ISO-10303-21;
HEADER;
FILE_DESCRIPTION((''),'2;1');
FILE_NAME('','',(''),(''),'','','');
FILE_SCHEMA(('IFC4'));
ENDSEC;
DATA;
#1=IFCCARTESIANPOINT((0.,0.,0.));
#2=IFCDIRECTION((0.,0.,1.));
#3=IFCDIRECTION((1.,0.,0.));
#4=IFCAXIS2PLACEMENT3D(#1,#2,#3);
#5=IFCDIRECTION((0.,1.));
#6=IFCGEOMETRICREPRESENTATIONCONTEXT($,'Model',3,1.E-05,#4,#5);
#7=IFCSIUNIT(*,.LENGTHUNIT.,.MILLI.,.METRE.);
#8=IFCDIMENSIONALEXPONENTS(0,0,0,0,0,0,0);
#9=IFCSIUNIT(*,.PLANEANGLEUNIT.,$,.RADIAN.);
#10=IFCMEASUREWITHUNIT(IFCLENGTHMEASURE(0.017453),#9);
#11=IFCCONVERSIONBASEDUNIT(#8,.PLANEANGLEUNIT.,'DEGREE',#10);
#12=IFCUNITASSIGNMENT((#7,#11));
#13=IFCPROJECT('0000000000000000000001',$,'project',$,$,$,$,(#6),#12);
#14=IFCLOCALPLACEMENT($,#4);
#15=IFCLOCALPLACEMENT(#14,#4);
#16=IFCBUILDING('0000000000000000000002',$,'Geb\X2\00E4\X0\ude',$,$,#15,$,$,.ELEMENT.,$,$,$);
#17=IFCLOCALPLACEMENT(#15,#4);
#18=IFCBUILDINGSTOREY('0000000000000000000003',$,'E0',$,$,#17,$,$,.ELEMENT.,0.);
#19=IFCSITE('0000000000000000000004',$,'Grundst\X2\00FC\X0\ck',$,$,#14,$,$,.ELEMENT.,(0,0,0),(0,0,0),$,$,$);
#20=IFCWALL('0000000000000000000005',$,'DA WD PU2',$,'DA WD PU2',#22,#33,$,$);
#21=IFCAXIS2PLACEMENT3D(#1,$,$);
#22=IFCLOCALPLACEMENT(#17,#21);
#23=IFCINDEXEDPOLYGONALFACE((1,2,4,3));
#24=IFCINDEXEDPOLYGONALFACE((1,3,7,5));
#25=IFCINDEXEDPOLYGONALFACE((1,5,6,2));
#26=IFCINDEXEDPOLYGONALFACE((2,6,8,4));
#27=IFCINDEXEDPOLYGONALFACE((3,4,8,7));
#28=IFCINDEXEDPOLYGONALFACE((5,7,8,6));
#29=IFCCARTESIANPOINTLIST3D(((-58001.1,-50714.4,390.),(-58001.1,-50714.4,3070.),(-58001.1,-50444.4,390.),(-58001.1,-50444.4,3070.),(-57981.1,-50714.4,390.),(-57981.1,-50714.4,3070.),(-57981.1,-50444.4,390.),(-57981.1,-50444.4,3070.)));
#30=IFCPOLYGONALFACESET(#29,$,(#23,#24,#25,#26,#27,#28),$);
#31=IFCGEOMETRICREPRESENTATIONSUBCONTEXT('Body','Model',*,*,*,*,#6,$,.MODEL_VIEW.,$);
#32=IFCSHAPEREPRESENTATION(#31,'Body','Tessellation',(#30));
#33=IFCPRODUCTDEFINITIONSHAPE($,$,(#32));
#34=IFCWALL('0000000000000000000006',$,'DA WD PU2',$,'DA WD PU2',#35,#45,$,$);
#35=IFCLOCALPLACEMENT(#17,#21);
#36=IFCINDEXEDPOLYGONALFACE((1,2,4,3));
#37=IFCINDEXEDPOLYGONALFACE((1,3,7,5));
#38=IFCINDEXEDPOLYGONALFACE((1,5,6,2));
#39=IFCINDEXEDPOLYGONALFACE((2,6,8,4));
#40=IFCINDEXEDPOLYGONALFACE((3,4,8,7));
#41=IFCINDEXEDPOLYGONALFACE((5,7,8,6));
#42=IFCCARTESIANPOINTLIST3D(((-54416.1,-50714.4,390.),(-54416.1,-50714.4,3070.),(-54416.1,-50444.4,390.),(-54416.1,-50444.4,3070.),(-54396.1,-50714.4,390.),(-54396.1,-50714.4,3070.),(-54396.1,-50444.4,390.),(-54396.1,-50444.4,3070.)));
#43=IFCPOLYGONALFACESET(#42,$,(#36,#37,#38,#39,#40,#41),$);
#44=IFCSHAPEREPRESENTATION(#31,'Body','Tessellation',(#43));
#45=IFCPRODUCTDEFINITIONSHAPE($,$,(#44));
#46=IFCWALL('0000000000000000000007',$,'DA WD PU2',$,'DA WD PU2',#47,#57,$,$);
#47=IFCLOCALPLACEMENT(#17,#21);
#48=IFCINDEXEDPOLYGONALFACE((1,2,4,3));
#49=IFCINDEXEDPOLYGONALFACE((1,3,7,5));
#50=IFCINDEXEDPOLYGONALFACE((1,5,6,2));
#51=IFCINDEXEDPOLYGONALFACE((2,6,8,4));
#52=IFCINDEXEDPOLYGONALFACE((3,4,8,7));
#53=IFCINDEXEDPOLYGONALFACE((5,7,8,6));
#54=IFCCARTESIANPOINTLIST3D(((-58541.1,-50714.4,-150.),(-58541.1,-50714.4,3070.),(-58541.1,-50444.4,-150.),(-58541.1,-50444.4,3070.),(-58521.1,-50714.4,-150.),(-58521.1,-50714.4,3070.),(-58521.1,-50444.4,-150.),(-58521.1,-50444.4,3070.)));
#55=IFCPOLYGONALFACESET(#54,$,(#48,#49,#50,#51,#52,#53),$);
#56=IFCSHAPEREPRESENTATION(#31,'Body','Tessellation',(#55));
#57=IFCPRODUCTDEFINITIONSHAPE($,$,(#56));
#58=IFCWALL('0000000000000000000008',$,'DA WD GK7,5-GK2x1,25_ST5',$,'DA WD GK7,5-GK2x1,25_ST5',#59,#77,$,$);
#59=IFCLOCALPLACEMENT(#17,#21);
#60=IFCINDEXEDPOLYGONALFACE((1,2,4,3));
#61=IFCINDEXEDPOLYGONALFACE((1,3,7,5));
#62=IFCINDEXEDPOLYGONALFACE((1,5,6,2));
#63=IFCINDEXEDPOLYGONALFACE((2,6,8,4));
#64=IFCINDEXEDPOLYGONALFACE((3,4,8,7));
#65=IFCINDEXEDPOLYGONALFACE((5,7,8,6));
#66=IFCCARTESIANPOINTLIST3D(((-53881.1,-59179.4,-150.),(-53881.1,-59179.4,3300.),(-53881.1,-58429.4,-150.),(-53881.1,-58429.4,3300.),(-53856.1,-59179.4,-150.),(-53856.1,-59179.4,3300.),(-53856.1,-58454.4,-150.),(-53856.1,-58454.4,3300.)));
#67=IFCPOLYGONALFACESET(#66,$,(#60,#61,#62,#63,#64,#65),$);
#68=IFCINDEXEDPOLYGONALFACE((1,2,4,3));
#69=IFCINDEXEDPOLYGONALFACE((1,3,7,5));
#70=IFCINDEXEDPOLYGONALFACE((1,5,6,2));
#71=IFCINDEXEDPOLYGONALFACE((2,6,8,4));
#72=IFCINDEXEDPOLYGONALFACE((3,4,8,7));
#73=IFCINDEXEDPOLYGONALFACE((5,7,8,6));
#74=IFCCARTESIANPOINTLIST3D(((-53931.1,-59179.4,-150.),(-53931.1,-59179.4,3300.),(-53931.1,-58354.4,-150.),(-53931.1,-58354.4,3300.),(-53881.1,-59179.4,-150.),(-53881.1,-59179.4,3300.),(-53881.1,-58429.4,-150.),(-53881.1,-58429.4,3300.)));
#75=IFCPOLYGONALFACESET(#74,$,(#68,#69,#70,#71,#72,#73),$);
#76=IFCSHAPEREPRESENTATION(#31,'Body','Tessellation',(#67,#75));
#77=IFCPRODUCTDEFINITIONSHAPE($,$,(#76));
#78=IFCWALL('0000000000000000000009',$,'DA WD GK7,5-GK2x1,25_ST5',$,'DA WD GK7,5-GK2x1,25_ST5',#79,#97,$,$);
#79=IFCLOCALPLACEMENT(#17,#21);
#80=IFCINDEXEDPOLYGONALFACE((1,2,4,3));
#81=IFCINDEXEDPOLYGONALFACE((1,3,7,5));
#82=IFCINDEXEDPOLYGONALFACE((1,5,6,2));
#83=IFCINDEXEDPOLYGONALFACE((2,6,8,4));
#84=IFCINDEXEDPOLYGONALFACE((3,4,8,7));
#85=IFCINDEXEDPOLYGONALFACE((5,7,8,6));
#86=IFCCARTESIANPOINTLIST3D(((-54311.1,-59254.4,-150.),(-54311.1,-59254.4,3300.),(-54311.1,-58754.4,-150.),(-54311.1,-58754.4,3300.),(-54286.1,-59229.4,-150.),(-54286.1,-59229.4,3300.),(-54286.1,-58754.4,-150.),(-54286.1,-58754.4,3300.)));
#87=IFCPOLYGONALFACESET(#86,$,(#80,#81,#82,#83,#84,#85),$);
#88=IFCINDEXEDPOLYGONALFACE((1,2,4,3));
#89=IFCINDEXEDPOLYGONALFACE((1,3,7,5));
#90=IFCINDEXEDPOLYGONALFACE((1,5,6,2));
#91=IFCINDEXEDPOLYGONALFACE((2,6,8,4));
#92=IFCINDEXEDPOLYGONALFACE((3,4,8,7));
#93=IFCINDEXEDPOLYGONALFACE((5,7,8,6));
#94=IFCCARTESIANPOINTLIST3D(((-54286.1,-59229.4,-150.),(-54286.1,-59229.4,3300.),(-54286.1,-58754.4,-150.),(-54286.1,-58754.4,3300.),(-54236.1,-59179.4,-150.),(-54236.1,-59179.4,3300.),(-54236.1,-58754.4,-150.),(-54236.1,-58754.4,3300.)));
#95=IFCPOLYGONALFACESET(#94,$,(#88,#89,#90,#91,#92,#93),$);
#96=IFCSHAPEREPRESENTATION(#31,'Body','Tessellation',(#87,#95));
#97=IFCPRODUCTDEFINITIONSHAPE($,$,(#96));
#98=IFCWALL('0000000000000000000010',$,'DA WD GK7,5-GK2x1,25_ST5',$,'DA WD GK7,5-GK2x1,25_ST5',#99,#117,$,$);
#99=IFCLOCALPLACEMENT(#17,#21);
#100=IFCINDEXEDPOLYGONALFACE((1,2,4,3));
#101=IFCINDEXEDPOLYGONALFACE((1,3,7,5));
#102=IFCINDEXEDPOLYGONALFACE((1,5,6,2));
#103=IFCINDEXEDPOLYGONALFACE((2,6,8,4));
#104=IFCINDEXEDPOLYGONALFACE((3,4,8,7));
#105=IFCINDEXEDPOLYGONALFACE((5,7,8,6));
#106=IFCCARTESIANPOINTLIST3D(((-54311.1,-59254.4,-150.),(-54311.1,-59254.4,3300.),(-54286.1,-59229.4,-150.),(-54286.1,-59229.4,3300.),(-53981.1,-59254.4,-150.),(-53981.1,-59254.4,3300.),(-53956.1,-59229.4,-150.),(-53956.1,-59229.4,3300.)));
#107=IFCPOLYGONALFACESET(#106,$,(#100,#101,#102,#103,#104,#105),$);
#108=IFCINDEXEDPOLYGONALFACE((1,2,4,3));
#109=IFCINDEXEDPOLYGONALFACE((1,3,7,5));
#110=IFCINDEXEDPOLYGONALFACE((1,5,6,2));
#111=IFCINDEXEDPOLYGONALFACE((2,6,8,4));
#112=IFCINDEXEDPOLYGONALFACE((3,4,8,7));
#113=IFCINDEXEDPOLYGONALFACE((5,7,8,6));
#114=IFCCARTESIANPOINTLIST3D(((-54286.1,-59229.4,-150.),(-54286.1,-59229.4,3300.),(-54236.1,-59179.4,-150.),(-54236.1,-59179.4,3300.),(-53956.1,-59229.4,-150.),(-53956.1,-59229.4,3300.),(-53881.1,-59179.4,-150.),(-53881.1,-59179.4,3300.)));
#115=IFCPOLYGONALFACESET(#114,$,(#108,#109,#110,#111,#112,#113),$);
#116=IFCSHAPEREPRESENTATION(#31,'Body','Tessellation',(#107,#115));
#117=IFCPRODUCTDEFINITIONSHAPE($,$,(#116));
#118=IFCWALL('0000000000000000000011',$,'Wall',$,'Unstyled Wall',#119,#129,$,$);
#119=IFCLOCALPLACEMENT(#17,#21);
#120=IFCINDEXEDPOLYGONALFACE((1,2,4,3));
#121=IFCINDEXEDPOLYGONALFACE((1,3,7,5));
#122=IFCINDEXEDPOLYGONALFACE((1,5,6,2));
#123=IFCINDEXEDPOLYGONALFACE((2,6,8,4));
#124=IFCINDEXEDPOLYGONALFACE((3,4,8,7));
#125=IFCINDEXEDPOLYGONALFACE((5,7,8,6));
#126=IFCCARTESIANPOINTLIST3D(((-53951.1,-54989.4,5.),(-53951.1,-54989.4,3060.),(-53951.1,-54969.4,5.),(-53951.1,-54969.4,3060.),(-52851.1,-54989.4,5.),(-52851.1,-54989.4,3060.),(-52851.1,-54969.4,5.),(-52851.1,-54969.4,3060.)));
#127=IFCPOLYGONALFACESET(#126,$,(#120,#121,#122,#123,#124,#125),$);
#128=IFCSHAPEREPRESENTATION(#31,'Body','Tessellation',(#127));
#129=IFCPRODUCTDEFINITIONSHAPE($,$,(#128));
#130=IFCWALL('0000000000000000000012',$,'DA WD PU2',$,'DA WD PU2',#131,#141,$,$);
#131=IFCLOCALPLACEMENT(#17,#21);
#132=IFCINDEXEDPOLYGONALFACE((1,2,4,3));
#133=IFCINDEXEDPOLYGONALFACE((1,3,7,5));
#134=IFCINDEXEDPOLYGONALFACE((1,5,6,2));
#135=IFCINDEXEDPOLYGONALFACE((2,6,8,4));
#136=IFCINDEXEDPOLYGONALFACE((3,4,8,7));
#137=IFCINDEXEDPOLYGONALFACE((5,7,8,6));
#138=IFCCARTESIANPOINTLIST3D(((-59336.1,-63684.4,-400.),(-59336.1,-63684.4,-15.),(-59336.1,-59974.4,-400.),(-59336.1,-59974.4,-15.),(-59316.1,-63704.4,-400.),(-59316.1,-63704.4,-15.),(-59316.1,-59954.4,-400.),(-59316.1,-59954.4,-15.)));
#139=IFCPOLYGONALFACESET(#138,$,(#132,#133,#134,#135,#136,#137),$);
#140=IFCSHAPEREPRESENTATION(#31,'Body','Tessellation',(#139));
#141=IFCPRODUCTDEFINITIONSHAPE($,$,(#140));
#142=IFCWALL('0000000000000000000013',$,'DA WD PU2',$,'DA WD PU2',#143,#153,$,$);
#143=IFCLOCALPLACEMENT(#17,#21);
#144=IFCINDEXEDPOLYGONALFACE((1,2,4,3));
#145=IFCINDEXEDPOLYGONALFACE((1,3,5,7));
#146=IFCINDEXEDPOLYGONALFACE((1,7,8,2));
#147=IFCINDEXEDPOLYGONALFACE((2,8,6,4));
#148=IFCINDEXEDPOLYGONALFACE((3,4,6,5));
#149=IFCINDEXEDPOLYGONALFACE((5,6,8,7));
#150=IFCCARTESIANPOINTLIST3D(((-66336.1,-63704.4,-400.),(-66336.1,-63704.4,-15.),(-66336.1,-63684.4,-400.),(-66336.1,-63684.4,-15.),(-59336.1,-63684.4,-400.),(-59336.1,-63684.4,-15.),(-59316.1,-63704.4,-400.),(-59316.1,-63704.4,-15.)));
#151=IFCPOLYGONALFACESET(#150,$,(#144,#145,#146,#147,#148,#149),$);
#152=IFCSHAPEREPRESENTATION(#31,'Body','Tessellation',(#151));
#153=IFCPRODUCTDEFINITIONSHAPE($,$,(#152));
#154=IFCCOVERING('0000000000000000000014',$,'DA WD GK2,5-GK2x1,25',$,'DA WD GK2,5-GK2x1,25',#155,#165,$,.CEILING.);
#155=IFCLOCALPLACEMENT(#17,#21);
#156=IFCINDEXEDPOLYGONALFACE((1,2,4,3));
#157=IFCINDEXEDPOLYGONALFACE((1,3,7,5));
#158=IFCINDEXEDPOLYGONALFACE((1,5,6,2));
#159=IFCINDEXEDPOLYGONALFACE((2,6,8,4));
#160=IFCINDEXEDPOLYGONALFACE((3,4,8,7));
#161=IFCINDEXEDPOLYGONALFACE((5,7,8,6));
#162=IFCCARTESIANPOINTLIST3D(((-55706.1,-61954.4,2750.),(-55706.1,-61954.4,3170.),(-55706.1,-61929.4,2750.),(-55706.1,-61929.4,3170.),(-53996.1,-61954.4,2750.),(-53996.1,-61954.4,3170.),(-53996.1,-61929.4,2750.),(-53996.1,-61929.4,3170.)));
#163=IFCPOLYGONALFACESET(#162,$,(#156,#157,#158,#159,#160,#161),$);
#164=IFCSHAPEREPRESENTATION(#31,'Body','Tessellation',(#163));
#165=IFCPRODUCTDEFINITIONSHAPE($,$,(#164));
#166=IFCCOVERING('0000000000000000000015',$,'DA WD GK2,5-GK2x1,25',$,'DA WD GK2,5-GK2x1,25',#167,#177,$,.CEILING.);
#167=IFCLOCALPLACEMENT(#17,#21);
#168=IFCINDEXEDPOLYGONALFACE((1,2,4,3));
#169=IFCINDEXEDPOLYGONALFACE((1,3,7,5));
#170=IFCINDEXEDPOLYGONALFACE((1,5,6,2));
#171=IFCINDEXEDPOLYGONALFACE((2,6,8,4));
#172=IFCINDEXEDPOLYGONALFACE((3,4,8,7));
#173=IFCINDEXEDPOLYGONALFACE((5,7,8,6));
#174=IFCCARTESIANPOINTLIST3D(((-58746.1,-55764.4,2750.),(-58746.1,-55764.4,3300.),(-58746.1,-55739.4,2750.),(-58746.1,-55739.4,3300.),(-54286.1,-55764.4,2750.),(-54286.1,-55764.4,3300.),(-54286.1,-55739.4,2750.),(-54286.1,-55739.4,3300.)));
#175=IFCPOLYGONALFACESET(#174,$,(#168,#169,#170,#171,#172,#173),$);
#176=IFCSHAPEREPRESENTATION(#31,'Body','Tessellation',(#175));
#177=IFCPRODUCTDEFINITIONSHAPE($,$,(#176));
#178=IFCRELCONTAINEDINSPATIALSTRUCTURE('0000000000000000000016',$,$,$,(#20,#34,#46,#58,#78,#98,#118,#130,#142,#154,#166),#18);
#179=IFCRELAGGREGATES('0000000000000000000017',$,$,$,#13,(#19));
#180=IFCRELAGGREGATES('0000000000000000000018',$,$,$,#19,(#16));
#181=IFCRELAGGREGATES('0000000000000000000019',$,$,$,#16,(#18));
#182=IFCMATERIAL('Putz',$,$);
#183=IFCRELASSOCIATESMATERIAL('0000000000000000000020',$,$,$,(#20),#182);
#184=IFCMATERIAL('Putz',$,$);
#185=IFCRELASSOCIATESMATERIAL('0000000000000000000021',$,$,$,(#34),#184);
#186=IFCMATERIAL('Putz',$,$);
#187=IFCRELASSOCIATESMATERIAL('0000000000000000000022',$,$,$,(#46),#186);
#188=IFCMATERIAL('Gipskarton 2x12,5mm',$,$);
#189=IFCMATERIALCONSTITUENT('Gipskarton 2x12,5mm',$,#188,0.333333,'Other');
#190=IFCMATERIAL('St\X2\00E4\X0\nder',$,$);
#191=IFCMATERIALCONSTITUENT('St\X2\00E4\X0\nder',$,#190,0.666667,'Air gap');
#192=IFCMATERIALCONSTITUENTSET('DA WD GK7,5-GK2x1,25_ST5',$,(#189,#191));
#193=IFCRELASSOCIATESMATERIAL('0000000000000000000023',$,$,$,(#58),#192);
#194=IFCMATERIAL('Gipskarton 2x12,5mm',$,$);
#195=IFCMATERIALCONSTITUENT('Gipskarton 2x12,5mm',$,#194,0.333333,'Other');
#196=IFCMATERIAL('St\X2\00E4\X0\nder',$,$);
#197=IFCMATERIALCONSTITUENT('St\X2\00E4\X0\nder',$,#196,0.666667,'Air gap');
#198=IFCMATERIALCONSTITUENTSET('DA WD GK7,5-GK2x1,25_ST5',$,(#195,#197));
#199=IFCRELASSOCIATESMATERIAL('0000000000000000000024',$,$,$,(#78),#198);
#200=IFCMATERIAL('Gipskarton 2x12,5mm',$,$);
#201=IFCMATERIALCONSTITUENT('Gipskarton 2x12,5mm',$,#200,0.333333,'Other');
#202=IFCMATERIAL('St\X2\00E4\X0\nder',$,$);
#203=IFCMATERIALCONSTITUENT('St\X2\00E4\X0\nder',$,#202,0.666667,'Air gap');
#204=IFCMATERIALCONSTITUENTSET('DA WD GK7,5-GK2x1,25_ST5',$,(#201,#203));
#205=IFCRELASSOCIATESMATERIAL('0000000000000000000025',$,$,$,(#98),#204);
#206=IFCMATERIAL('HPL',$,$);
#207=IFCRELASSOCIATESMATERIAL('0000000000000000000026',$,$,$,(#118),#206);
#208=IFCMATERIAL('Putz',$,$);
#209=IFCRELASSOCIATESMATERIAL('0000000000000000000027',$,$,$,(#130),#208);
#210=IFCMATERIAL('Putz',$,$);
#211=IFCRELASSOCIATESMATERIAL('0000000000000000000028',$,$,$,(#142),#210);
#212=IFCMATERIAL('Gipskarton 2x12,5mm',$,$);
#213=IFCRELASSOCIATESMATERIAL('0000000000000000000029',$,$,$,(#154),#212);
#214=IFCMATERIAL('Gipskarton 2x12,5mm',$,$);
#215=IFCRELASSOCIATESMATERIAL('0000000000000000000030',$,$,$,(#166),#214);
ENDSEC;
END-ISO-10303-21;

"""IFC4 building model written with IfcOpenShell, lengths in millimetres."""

from ifc_helpers import new_model, entity, si_unit, converted_unit, direction, frame, origin_with_axes, place, context, subcontext, project, spatial, line, indexed_curve, outline, extrude, material, constituent, constituent_set, element, save


model = new_model("IFC4")

# Units and contexts
model_context = context("Model", 3, precision=1e-05, world=origin_with_axes(), true_north=direction((0.0, 1.0)))
body_context = subcontext(model_context, "Body", "Model", "MODEL_VIEW")
ifc_project = project(units=[si_unit("LENGTHUNIT", "METRE", prefix="MILLI"), converted_unit("PLANEANGLEUNIT", "DEGREE", entity("IfcLengthMeasure", 0.017453), si_unit("PLANEANGLEUNIT", "RADIAN"), dimensions=[0, 0, 0, 0, 0, 0, 0])], contexts=[model_context])

# Site, building, storey
site_placement = place(None, origin_with_axes())
site = spatial("IfcSite", under=ifc_project, at=site_placement, Name="Grundstück", CompositionType="ELEMENT", RefLatitude=(0, 0, 0), RefLongitude=(0, 0, 0))
building_placement = place(site_placement, origin_with_axes())
building = spatial("IfcBuilding", under=site, at=building_placement, Name="Gebäude", CompositionType="ELEMENT")
storey_placement = place(building_placement, origin_with_axes())
storey = spatial("IfcBuildingStorey", under=building, at=storey_placement, Name="E0", CompositionType="ELEMENT", Elevation=0.0)

# Walls
ifc_material_1 = material(Name="Putz")
wall_1_placement = place(storey_placement, frame((-57991.1, -50714.4, 390.0), z_axis=(0.0, 0.0, 1.0), x_axis=(0.0, 1.0, 0.0)))
element("IfcWall", 1, at=wall_1_placement, inside=storey, material=ifc_material_1, Name="DA WD PU2", ObjectType="DA WD PU2", context=body_context, shape_type="SweptSolid", body=[
    extrude(outline(indexed_curve([(0.0, -10.0), (0.0, 10.0), (270.0, 10.0), (270.0, -10.0)], segments=[line(1, 2), line(2, 3), line(3, 4), line(4, 1)])), origin_with_axes(), (0.0, 0.0, 1.0), 2680.0),
])
ifc_material_2 = material(Name="Putz")
wall_2_placement = place(storey_placement, frame((-54406.1, -50714.4, 390.0), z_axis=(0.0, 0.0, 1.0), x_axis=(0.0, 1.0, 0.0)))
element("IfcWall", 2, at=wall_2_placement, inside=storey, material=ifc_material_2, Name="DA WD PU2", ObjectType="DA WD PU2", context=body_context, shape_type="SweptSolid", body=[
    extrude(outline(indexed_curve([(0.0, -10.0), (0.0, 10.0), (270.0, 10.0), (270.0, -10.0)], segments=[line(1, 2), line(2, 3), line(3, 4), line(4, 1)])), origin_with_axes(), (0.0, 0.0, 1.0), 2680.0),
])
ifc_material_3 = material(Name="Putz")
wall_3_placement = place(storey_placement, frame((-58531.1, -50714.4, -150.0), z_axis=(0.0, 0.0, 1.0), x_axis=(0.0, 1.0, 0.0)))
element("IfcWall", 3, at=wall_3_placement, inside=storey, material=ifc_material_3, Name="DA WD PU2", ObjectType="DA WD PU2", context=body_context, shape_type="SweptSolid", body=[
    extrude(outline(indexed_curve([(0.0, -10.0), (0.0, 10.0), (270.0, 10.0), (270.0, -10.0)], segments=[line(1, 2), line(2, 3), line(3, 4), line(4, 1)])), origin_with_axes(), (0.0, 0.0, 1.0), 3220.0),
])
ifc_material_4 = material(Name="Gipskarton 2x12,5mm")
ifc_constituent_1 = constituent(ifc_material_4, Name="Gipskarton 2x12,5mm", Category="Other", fraction=0.333333)
ifc_material_5 = material(Name="Ständer")
ifc_constituent_2 = constituent(ifc_material_5, Name="Ständer", Category="Air gap", fraction=0.666667)
ifc_constituent_set_1 = constituent_set(constituents=[ifc_constituent_1, ifc_constituent_2], Name="DA WD GK7,5-GK2x1,25_ST5")
wall_4_placement = place(storey_placement, frame((-53893.6, -58391.9, -150.0), z_axis=(0.0, 0.0, 1.0), x_axis=(0.0, -1.0, 0.0)))
element("IfcWall", 4, at=wall_4_placement, inside=storey, material=ifc_constituent_set_1, Name="DA WD GK7,5-GK2x1,25_ST5", ObjectType="DA WD GK7,5-GK2x1,25_ST5", context=body_context, shape_type="SweptSolid", body=[
    extrude(outline(indexed_curve([(787.5, 37.5), (787.5, 12.5), (37.5, 12.5), (62.5, 37.5)], segments=[line(1, 2), line(2, 3), line(3, 4), line(4, 1)])), origin_with_axes(), (0.0, 0.0, 1.0), 3450.0),
    extrude(outline(indexed_curve([(787.5, 12.5), (787.5, -37.5), (-37.5, -37.5), (37.5, 12.5)], segments=[line(1, 2), line(2, 3), line(3, 4), line(4, 1)])), origin_with_axes(), (0.0, 0.0, 1.0), 3450.0),
])
ifc_material_6 = material(Name="Gipskarton 2x12,5mm")
ifc_constituent_3 = constituent(ifc_material_6, Name="Gipskarton 2x12,5mm", Category="Other", fraction=0.333333)
ifc_material_7 = material(Name="Ständer")
ifc_constituent_4 = constituent(ifc_material_7, Name="Ständer", Category="Air gap", fraction=0.666667)
ifc_constituent_set_2 = constituent_set(constituents=[ifc_constituent_3, ifc_constituent_4], Name="DA WD GK7,5-GK2x1,25_ST5")
wall_5_placement = place(storey_placement, frame((-54273.6, -59216.9, -150.0), z_axis=(0.0, 0.0, 1.0), x_axis=(0.0, 1.0, 0.0)))
element("IfcWall", 5, at=wall_5_placement, inside=storey, material=ifc_constituent_set_2, Name="DA WD GK7,5-GK2x1,25_ST5", ObjectType="DA WD GK7,5-GK2x1,25_ST5", context=body_context, shape_type="SweptSolid", body=[
    extrude(outline(indexed_curve([(462.5, 37.5), (462.5, 12.5), (-12.5, 12.5), (-37.5, 37.5)], segments=[line(1, 2), line(2, 3), line(3, 4), line(4, 1)])), origin_with_axes(), (0.0, 0.0, 1.0), 3450.0),
    extrude(outline(indexed_curve([(462.5, 12.5), (462.5, -37.5), (37.5, -37.5), (-12.5, 12.5)], segments=[line(1, 2), line(2, 3), line(3, 4), line(4, 1)])), origin_with_axes(), (0.0, 0.0, 1.0), 3450.0),
])
ifc_material_8 = material(Name="Gipskarton 2x12,5mm")
ifc_constituent_5 = constituent(ifc_material_8, Name="Gipskarton 2x12,5mm", Category="Other", fraction=0.333333)
ifc_material_9 = material(Name="Ständer")
ifc_constituent_6 = constituent(ifc_material_9, Name="Ständer", Category="Air gap", fraction=0.666667)
ifc_constituent_set_3 = constituent_set(constituents=[ifc_constituent_5, ifc_constituent_6], Name="DA WD GK7,5-GK2x1,25_ST5")
wall_6_placement = place(storey_placement, frame((-53918.6, -59216.9, -150.0), z_axis=(0.0, 0.0, 1.0), x_axis=(-1.0, 0.0, 0.0)))
element("IfcWall", 6, at=wall_6_placement, inside=storey, material=ifc_constituent_set_3, Name="DA WD GK7,5-GK2x1,25_ST5", ObjectType="DA WD GK7,5-GK2x1,25_ST5", context=body_context, shape_type="SweptSolid", body=[
    extrude(outline(indexed_curve([(392.5, 37.5), (367.5, 12.5), (37.5, 12.5), (62.5, 37.5)], segments=[line(1, 2), line(2, 3), line(3, 4), line(4, 1)])), origin_with_axes(), (0.0, 0.0, 1.0), 3450.0),
    extrude(outline(indexed_curve([(367.5, 12.5), (317.5, -37.5), (-37.5, -37.5), (37.5, 12.5)], segments=[line(1, 2), line(2, 3), line(3, 4), line(4, 1)])), origin_with_axes(), (0.0, 0.0, 1.0), 3450.0),
])
ifc_material_10 = material(Name="HPL")
wall_7_placement = place(storey_placement, frame((-53951.1, -54979.4, 5.0), z_axis=(0.0, 0.0, 1.0), x_axis=(1.0, 0.0, 0.0)))
element("IfcWall", 7, at=wall_7_placement, inside=storey, material=ifc_material_10, Name="Wall", ObjectType="Unstyled Wall", context=body_context, shape_type="SweptSolid", body=[
    extrude(outline(indexed_curve([(0.0, -10.0), (0.0, 10.0), (1100.0, 10.0), (1100.0, -10.0)], segments=[line(1, 2), line(2, 3), line(3, 4), line(4, 1)])), origin_with_axes(), (0.0, 0.0, 1.0), 3055.0),
])
ifc_material_11 = material(Name="Putz")
wall_8_placement = place(storey_placement, frame((-59326.1, -59964.4, -400.0), z_axis=(0.0, 0.0, 1.0), x_axis=(0.0, -1.0, 0.0)))
element("IfcWall", 8, at=wall_8_placement, inside=storey, material=ifc_material_11, Name="DA WD PU2", ObjectType="DA WD PU2", context=body_context, shape_type="SweptSolid", body=[
    extrude(outline(indexed_curve([(10.0, -10.0), (-10.0, 10.0), (3740.0, 10.0), (3720.0, -10.0)], segments=[line(1, 2), line(2, 3), line(3, 4), line(4, 1)])), origin_with_axes(), (0.0, 0.0, 1.0), 385.0),
])
ifc_material_12 = material(Name="Putz")
wall_9_placement = place(storey_placement, frame((-59326.1, -63694.4, -400.0), z_axis=(0.0, 0.0, 1.0), x_axis=(-1.0, 0.0, 0.0)))
element("IfcWall", 9, at=wall_9_placement, inside=storey, material=ifc_material_12, Name="DA WD PU2", ObjectType="DA WD PU2", context=body_context, shape_type="SweptSolid", body=[
    extrude(outline(indexed_curve([(10.0, -10.0), (-10.0, 10.0), (7010.0, 10.0), (7010.0, -10.0)], segments=[line(1, 2), line(2, 3), line(3, 4), line(4, 1)])), origin_with_axes(), (0.0, 0.0, 1.0), 385.0),
])

# Coverings
ifc_material_13 = material(Name="Gipskarton 2x12,5mm")
covering_1_placement = place(storey_placement, frame((-55706.1, -61941.9, 2750.0), z_axis=(0.0, 0.0, 1.0), x_axis=(1.0, 0.0, 0.0)))
element("IfcCovering", 10, at=covering_1_placement, inside=storey, material=ifc_material_13, Name="DA WD GK2,5-GK2x1,25", ObjectType="DA WD GK2,5-GK2x1,25", PredefinedType="CEILING", context=body_context, shape_type="SweptSolid", body=[
    extrude(outline(indexed_curve([(0.0, -12.5), (0.0, 12.5), (1710.0, 12.5), (1710.0, -12.5)], segments=[line(1, 2), line(2, 3), line(3, 4), line(4, 1)])), origin_with_axes(), (0.0, 0.0, 1.0), 420.0),
])
ifc_material_14 = material(Name="Gipskarton 2x12,5mm")
covering_2_placement = place(storey_placement, frame((-58746.1, -55751.9, 2750.0), z_axis=(0.0, 0.0, 1.0), x_axis=(1.0, 0.0, 0.0)))
element("IfcCovering", 11, at=covering_2_placement, inside=storey, material=ifc_material_14, Name="DA WD GK2,5-GK2x1,25", ObjectType="DA WD GK2,5-GK2x1,25", PredefinedType="CEILING", context=body_context, shape_type="SweptSolid", body=[
    extrude(outline(indexed_curve([(0.0, -12.5), (0.0, 12.5), (4460.0, 12.5), (4460.0, -12.5)], segments=[line(1, 2), line(2, 3), line(3, 4), line(4, 1)])), origin_with_axes(), (0.0, 0.0, 1.0), 550.0),
])

save(model, "model.ifc")
